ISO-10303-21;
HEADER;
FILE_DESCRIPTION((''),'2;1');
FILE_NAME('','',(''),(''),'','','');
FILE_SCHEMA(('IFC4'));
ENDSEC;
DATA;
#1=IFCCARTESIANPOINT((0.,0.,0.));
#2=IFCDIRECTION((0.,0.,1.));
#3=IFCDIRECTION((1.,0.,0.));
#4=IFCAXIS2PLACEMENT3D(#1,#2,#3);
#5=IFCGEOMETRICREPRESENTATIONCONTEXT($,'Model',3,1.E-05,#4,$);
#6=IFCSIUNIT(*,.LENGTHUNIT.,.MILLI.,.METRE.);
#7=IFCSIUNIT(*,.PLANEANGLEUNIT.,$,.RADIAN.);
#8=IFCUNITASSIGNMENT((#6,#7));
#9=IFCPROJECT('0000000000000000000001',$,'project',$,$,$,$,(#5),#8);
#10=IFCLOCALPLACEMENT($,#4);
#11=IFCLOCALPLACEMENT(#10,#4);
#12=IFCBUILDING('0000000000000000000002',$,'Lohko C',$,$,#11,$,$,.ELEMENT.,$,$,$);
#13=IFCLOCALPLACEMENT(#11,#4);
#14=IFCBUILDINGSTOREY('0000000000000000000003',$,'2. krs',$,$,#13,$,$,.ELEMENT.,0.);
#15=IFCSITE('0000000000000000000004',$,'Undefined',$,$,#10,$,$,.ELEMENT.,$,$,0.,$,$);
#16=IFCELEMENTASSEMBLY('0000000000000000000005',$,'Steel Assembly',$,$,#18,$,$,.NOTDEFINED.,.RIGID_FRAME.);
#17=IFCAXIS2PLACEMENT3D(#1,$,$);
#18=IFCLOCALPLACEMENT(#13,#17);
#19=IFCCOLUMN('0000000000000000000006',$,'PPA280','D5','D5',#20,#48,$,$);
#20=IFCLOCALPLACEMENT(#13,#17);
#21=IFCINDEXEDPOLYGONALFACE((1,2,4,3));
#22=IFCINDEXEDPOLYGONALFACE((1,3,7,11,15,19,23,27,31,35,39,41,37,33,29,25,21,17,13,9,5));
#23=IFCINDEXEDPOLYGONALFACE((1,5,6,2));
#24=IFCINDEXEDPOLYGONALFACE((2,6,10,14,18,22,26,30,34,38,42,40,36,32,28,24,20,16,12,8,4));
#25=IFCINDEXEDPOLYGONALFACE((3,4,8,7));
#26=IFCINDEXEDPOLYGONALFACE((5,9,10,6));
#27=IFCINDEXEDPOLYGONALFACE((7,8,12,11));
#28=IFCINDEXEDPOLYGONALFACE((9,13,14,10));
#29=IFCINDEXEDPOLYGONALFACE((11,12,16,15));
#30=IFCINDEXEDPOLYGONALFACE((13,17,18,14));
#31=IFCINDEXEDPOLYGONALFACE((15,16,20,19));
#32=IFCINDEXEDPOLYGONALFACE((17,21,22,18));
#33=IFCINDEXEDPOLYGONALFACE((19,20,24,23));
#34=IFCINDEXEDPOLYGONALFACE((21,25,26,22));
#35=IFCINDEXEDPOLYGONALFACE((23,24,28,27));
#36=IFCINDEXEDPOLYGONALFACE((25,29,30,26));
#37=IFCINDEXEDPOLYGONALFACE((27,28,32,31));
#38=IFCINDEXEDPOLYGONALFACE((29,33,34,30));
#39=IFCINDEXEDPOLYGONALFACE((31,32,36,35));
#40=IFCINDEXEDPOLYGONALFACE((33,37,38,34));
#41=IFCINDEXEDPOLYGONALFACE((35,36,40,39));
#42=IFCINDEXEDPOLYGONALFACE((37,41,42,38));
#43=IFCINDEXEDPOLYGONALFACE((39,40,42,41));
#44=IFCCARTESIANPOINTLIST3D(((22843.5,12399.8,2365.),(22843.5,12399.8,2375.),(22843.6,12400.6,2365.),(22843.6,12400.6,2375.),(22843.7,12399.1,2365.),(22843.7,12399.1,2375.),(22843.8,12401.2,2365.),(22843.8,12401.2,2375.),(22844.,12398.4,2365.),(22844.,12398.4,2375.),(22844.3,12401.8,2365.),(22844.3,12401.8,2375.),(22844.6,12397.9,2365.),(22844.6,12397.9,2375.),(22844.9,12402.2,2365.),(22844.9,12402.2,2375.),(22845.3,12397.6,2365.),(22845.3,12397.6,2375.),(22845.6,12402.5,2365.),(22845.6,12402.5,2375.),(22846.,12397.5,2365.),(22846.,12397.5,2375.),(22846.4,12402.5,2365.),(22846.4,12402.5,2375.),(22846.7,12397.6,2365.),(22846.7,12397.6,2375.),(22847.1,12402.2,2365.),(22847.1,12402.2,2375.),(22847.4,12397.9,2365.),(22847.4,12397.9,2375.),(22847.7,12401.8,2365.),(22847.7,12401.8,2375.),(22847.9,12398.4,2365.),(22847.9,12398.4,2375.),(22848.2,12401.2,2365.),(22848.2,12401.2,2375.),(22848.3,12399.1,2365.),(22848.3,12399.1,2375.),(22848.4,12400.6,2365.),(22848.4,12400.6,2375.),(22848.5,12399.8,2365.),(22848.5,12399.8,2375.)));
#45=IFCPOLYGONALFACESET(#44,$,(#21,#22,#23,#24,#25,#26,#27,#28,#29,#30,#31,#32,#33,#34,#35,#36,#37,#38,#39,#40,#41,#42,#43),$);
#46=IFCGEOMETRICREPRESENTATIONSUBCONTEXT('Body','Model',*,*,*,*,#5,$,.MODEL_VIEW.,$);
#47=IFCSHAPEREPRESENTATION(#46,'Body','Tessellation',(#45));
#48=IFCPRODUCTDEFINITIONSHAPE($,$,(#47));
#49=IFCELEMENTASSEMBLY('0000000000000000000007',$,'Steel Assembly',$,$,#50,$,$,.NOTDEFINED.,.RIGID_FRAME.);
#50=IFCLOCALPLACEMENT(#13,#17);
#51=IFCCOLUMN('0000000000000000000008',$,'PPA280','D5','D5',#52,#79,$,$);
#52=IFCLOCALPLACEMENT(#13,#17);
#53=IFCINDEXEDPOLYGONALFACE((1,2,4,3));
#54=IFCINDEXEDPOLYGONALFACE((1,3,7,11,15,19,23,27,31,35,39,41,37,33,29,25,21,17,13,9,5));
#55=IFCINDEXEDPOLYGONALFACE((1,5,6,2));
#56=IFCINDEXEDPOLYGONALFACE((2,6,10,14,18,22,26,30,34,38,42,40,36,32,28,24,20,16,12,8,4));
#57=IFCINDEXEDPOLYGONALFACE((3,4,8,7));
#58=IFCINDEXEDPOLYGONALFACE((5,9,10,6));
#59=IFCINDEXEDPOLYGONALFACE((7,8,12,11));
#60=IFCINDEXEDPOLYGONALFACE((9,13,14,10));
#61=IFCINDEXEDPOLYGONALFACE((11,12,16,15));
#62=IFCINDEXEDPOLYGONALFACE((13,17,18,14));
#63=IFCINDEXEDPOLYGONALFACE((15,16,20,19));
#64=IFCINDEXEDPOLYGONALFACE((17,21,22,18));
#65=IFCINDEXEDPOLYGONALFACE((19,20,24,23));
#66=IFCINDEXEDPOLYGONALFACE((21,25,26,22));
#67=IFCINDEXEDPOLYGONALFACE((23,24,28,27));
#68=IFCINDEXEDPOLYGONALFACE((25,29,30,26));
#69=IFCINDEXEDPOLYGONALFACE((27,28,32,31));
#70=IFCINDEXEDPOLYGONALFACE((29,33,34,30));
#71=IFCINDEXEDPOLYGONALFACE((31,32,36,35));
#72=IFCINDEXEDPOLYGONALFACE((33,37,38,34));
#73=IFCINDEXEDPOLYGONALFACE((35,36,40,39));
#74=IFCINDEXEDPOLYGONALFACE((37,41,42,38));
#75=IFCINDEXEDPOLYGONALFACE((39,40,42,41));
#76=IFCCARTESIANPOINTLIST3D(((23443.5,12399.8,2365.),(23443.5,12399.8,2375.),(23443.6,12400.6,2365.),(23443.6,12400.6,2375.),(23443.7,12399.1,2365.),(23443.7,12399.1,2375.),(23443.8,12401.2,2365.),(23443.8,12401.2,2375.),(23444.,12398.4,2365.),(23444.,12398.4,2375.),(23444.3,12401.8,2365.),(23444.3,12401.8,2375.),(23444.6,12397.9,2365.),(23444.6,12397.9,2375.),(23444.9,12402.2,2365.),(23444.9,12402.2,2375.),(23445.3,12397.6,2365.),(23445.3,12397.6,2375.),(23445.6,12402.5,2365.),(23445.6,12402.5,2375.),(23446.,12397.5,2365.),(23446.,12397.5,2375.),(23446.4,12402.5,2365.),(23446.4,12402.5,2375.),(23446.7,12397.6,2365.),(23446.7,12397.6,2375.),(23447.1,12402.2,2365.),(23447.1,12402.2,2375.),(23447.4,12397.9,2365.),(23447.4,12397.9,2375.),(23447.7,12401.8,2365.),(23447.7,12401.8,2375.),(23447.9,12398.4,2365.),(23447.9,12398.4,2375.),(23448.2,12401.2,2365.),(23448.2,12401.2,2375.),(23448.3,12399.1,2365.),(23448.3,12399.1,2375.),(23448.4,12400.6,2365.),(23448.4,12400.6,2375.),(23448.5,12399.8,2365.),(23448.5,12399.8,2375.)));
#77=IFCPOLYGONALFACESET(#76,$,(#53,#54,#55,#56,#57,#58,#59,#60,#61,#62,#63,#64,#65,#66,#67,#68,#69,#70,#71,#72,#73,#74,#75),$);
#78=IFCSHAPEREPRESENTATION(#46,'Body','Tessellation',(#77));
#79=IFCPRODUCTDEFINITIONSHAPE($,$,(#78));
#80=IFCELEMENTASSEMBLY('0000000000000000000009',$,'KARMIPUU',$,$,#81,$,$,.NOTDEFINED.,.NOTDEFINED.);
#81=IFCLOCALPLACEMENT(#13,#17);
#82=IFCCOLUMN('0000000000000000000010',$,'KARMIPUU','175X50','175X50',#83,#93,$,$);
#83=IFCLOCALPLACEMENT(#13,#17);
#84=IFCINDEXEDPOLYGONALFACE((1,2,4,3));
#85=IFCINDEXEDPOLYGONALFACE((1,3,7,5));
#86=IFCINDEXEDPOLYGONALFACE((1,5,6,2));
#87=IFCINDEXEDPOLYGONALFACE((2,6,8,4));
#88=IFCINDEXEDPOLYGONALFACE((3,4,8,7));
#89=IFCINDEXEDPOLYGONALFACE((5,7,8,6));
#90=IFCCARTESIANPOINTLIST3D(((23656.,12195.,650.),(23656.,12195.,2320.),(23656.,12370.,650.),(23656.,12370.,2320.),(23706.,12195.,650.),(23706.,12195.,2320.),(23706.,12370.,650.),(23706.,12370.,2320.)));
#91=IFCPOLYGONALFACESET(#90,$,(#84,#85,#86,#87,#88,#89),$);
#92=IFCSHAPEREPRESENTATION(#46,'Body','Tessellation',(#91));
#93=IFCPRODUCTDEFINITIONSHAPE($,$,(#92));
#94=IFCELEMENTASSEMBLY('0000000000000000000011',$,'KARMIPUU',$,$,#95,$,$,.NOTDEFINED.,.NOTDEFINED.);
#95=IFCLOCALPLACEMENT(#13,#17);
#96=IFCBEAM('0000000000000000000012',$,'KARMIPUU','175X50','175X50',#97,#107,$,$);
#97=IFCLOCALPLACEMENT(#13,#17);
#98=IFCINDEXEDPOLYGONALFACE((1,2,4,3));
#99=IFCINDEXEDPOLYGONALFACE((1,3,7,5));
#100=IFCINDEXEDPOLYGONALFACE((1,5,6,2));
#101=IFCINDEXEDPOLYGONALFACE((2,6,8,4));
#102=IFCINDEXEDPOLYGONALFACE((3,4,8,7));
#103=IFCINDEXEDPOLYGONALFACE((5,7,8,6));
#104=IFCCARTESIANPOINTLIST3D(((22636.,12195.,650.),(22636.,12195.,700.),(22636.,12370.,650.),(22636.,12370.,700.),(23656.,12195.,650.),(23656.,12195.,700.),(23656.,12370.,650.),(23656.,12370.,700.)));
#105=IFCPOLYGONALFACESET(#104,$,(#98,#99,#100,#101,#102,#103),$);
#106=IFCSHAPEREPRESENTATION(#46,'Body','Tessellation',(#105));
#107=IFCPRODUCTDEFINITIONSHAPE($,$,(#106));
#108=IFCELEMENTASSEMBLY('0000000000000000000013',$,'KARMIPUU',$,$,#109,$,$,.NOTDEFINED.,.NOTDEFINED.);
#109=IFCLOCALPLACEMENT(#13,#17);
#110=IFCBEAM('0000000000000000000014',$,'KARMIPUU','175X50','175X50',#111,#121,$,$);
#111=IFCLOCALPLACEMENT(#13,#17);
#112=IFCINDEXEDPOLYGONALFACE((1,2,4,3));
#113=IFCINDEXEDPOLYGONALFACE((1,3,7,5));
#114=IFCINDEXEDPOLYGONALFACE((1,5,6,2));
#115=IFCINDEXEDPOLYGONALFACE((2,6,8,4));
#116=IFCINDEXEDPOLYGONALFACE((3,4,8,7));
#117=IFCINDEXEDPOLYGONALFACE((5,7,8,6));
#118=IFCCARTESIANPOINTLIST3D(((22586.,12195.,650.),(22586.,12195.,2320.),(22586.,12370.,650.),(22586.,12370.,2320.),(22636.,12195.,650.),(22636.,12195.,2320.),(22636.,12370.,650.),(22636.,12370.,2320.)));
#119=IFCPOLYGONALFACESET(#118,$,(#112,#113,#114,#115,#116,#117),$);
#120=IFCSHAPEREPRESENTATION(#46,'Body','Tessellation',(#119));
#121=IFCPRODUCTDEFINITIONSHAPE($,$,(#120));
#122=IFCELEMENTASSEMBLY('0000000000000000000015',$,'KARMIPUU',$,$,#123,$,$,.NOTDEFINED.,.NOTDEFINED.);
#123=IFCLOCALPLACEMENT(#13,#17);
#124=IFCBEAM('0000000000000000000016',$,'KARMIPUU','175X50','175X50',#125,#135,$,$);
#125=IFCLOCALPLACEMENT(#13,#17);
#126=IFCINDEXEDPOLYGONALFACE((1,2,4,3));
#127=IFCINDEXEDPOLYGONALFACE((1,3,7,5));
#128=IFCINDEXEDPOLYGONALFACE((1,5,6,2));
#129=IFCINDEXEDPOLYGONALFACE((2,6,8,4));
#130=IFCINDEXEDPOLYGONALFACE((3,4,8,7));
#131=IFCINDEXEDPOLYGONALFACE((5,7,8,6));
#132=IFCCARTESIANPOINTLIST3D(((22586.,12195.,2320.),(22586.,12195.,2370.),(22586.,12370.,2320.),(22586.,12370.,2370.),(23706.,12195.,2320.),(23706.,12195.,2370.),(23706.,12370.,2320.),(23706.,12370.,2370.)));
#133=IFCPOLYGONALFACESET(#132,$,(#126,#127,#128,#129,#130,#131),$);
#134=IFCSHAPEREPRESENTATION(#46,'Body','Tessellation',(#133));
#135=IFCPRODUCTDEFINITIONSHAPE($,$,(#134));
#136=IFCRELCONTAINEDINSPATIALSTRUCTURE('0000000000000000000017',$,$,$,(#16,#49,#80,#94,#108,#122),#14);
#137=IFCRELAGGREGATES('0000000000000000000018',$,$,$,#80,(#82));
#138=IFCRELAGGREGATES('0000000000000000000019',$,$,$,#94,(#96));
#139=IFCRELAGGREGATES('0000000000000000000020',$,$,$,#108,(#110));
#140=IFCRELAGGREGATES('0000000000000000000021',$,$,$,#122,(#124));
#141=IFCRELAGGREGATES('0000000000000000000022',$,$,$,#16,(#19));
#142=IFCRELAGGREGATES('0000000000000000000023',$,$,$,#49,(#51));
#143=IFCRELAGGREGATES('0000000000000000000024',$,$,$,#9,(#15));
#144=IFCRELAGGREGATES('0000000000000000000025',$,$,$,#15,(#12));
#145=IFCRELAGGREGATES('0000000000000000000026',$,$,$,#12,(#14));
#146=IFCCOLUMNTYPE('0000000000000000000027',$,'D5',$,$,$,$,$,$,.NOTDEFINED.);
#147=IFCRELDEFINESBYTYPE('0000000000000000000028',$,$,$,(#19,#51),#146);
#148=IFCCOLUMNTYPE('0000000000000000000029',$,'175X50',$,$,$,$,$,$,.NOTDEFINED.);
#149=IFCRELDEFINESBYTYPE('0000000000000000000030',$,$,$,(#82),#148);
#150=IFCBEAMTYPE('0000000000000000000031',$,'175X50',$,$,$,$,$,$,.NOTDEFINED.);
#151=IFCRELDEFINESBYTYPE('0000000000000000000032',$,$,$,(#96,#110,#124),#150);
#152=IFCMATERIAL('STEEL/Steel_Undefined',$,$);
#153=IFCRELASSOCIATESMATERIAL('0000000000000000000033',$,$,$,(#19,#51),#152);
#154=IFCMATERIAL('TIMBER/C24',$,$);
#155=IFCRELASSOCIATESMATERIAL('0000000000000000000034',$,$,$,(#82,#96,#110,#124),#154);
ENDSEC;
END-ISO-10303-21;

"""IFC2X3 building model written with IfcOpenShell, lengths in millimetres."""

from ifc_helpers import new_model, si_unit, frame, origin_with_axes, origin_2d_with_axis, place, context, subcontext, project, spatial, rectangle, circle, extrude, material, type_object, element, aggregate, save


model = new_model("IFC2X3")

# Units and contexts
model_context = context("Model", 3, precision=1e-05, world=origin_with_axes())
body_context = subcontext(model_context, "Body", "Model", "MODEL_VIEW")
ifc_project = project(units=[si_unit("LENGTHUNIT", "METRE", prefix="MILLI"), si_unit("PLANEANGLEUNIT", "RADIAN")], contexts=[model_context])

# Site, building, storey
site_placement = place(None, origin_with_axes())
site = spatial("IfcSite", under=ifc_project, at=site_placement, Name="Undefined", CompositionType="ELEMENT", RefElevation=0.0)
building_placement = place(site_placement, origin_with_axes())
building = spatial("IfcBuilding", under=site, at=building_placement, Name="Lohko C", CompositionType="ELEMENT")
storey_placement = place(building_placement, origin_with_axes())
storey = spatial("IfcBuildingStorey", under=building, at=storey_placement, Name="2. krs", CompositionType="ELEMENT", Elevation=0.0)

# Element assemblies, columns
assembly_1_placement = place(storey_placement, origin_with_axes())
assembly_1 = element("IfcElementAssembly", 1, at=assembly_1_placement, inside=storey, Name="Steel Assembly", AssemblyPlace="NOTDEFINED", PredefinedType="RIGID_FRAME")
ifc_material_1 = material(Name="STEEL/Steel_Undefined")
column_type_1 = type_object("IfcColumnType", Name="D5", PredefinedType="NOTDEFINED")
column_1_placement = place(assembly_1_placement, frame((22846.0, 12400.0, 2365.0), z_axis=(0.0, 0.0, 1.0), x_axis=(-1.0, 0.0, 0.0)))
column_1 = element("IfcColumn", 2, at=column_1_placement, type_object=column_type_1, material=ifc_material_1, Name="PPA280", Description="D5", ObjectType="D5", context=body_context, shape_type="SweptSolid", body=[
    extrude(circle(Radius=2.5, at=origin_2d_with_axis()), frame((0.0, 0.0, 10.0), z_axis=(0.0, 0.0, -1.0), x_axis=(0.0, 1.0, 0.0)), (0.0, 0.0, 1.0), 10.0),
])
assembly_2_placement = place(storey_placement, origin_with_axes())
assembly_2 = element("IfcElementAssembly", 3, at=assembly_2_placement, inside=storey, Name="Steel Assembly", AssemblyPlace="NOTDEFINED", PredefinedType="RIGID_FRAME")
column_2_placement = place(assembly_2_placement, frame((23446.0, 12400.0, 2365.0), z_axis=(0.0, 0.0, 1.0), x_axis=(-1.0, 0.0, 0.0)))
column_2 = element("IfcColumn", 4, at=column_2_placement, type_object=column_type_1, material=ifc_material_1, Name="PPA280", Description="D5", ObjectType="D5", context=body_context, shape_type="SweptSolid", body=[
    extrude(circle(Radius=2.5, at=origin_2d_with_axis()), frame((0.0, 0.0, 10.0), z_axis=(0.0, 0.0, -1.0), x_axis=(0.0, 1.0, 0.0)), (0.0, 0.0, 1.0), 10.0),
])
assembly_3_placement = place(storey_placement, origin_with_axes())
assembly_3 = element("IfcElementAssembly", 5, at=assembly_3_placement, inside=storey, Name="KARMIPUU", AssemblyPlace="NOTDEFINED", PredefinedType="NOTDEFINED")
ifc_material_2 = material(Name="TIMBER/C24")
column_type_2 = type_object("IfcColumnType", Name="175X50", PredefinedType="NOTDEFINED")
column_3_placement = place(assembly_3_placement, frame((23681.0, 12282.5, 650.0), z_axis=(0.0, 0.0, 1.0), x_axis=(0.0, -1.0, 0.0)))
column_3 = element("IfcColumn", 6, at=column_3_placement, type_object=column_type_2, material=ifc_material_2, Name="KARMIPUU", Description="175X50", ObjectType="175X50", context=body_context, shape_type="SweptSolid", body=[
    extrude(rectangle(XDim=50.0, YDim=175.0, at=origin_2d_with_axis()), frame((0.0, 0.0, 1670.0), z_axis=(0.0, 0.0, -1.0), x_axis=(0.0, 1.0, 0.0)), (0.0, 0.0, 1.0), 1670.0),
])
aggregate(assembly_3, [column_3])

# Element assemblies, beams
assembly_4_placement = place(storey_placement, origin_with_axes())
assembly_4 = element("IfcElementAssembly", 7, at=assembly_4_placement, inside=storey, Name="KARMIPUU", AssemblyPlace="NOTDEFINED", PredefinedType="NOTDEFINED")
beam_type = type_object("IfcBeamType", Name="175X50", PredefinedType="NOTDEFINED")
beam_1_placement = place(assembly_4_placement, frame((22636.0, 12282.5, 675.0), z_axis=(0.0, -1.0, 0.0), x_axis=(1.0, 0.0, 0.0)))
beam_1 = element("IfcBeam", 8, at=beam_1_placement, type_object=beam_type, material=ifc_material_2, Name="KARMIPUU", Description="175X50", ObjectType="175X50", context=body_context, shape_type="SweptSolid", body=[
    extrude(rectangle(XDim=50.0, YDim=175.0, at=origin_2d_with_axis()), frame((1020.0, 0.0, 0.0), z_axis=(-1.0, 0.0, 0.0), x_axis=(0.0, -1.0, 0.0)), (0.0, 0.0, 1.0), 1020.0),
])
aggregate(assembly_4, [beam_1])
assembly_5_placement = place(storey_placement, origin_with_axes())
assembly_5 = element("IfcElementAssembly", 9, at=assembly_5_placement, inside=storey, Name="KARMIPUU", AssemblyPlace="NOTDEFINED", PredefinedType="NOTDEFINED")
beam_2_placement = place(assembly_5_placement, frame((22611.0, 12282.5, 2320.0), z_axis=(0.0, -1.0, 0.0), x_axis=(0.0, 0.0, -1.0)))
beam_2 = element("IfcBeam", 10, at=beam_2_placement, type_object=beam_type, material=ifc_material_2, Name="KARMIPUU", Description="175X50", ObjectType="175X50", context=body_context, shape_type="SweptSolid", body=[
    extrude(rectangle(XDim=50.0, YDim=175.0, at=origin_2d_with_axis()), frame((1670.0, 0.0, 0.0), z_axis=(-1.0, 0.0, 0.0), x_axis=(0.0, -1.0, 0.0)), (0.0, 0.0, 1.0), 1670.0),
])
aggregate(assembly_5, [beam_2])
assembly_6_placement = place(storey_placement, origin_with_axes())
assembly_6 = element("IfcElementAssembly", 11, at=assembly_6_placement, inside=storey, Name="KARMIPUU", AssemblyPlace="NOTDEFINED", PredefinedType="NOTDEFINED")
beam_3_placement = place(assembly_6_placement, frame((23706.0, 12282.5, 2345.0), z_axis=(0.0, -1.0, 0.0), x_axis=(-1.0, 0.0, 0.0)))
beam_3 = element("IfcBeam", 12, at=beam_3_placement, type_object=beam_type, material=ifc_material_2, Name="KARMIPUU", Description="175X50", ObjectType="175X50", context=body_context, shape_type="SweptSolid", body=[
    extrude(rectangle(XDim=50.0, YDim=175.0, at=origin_2d_with_axis()), frame((1120.0, 0.0, 0.0), z_axis=(-1.0, 0.0, 0.0), x_axis=(0.0, -1.0, 0.0)), (0.0, 0.0, 1.0), 1120.0),
])
aggregate(assembly_6, [beam_3])

aggregate(assembly_1, [column_1])
aggregate(assembly_2, [column_2])

save(model, "model.ifc")
